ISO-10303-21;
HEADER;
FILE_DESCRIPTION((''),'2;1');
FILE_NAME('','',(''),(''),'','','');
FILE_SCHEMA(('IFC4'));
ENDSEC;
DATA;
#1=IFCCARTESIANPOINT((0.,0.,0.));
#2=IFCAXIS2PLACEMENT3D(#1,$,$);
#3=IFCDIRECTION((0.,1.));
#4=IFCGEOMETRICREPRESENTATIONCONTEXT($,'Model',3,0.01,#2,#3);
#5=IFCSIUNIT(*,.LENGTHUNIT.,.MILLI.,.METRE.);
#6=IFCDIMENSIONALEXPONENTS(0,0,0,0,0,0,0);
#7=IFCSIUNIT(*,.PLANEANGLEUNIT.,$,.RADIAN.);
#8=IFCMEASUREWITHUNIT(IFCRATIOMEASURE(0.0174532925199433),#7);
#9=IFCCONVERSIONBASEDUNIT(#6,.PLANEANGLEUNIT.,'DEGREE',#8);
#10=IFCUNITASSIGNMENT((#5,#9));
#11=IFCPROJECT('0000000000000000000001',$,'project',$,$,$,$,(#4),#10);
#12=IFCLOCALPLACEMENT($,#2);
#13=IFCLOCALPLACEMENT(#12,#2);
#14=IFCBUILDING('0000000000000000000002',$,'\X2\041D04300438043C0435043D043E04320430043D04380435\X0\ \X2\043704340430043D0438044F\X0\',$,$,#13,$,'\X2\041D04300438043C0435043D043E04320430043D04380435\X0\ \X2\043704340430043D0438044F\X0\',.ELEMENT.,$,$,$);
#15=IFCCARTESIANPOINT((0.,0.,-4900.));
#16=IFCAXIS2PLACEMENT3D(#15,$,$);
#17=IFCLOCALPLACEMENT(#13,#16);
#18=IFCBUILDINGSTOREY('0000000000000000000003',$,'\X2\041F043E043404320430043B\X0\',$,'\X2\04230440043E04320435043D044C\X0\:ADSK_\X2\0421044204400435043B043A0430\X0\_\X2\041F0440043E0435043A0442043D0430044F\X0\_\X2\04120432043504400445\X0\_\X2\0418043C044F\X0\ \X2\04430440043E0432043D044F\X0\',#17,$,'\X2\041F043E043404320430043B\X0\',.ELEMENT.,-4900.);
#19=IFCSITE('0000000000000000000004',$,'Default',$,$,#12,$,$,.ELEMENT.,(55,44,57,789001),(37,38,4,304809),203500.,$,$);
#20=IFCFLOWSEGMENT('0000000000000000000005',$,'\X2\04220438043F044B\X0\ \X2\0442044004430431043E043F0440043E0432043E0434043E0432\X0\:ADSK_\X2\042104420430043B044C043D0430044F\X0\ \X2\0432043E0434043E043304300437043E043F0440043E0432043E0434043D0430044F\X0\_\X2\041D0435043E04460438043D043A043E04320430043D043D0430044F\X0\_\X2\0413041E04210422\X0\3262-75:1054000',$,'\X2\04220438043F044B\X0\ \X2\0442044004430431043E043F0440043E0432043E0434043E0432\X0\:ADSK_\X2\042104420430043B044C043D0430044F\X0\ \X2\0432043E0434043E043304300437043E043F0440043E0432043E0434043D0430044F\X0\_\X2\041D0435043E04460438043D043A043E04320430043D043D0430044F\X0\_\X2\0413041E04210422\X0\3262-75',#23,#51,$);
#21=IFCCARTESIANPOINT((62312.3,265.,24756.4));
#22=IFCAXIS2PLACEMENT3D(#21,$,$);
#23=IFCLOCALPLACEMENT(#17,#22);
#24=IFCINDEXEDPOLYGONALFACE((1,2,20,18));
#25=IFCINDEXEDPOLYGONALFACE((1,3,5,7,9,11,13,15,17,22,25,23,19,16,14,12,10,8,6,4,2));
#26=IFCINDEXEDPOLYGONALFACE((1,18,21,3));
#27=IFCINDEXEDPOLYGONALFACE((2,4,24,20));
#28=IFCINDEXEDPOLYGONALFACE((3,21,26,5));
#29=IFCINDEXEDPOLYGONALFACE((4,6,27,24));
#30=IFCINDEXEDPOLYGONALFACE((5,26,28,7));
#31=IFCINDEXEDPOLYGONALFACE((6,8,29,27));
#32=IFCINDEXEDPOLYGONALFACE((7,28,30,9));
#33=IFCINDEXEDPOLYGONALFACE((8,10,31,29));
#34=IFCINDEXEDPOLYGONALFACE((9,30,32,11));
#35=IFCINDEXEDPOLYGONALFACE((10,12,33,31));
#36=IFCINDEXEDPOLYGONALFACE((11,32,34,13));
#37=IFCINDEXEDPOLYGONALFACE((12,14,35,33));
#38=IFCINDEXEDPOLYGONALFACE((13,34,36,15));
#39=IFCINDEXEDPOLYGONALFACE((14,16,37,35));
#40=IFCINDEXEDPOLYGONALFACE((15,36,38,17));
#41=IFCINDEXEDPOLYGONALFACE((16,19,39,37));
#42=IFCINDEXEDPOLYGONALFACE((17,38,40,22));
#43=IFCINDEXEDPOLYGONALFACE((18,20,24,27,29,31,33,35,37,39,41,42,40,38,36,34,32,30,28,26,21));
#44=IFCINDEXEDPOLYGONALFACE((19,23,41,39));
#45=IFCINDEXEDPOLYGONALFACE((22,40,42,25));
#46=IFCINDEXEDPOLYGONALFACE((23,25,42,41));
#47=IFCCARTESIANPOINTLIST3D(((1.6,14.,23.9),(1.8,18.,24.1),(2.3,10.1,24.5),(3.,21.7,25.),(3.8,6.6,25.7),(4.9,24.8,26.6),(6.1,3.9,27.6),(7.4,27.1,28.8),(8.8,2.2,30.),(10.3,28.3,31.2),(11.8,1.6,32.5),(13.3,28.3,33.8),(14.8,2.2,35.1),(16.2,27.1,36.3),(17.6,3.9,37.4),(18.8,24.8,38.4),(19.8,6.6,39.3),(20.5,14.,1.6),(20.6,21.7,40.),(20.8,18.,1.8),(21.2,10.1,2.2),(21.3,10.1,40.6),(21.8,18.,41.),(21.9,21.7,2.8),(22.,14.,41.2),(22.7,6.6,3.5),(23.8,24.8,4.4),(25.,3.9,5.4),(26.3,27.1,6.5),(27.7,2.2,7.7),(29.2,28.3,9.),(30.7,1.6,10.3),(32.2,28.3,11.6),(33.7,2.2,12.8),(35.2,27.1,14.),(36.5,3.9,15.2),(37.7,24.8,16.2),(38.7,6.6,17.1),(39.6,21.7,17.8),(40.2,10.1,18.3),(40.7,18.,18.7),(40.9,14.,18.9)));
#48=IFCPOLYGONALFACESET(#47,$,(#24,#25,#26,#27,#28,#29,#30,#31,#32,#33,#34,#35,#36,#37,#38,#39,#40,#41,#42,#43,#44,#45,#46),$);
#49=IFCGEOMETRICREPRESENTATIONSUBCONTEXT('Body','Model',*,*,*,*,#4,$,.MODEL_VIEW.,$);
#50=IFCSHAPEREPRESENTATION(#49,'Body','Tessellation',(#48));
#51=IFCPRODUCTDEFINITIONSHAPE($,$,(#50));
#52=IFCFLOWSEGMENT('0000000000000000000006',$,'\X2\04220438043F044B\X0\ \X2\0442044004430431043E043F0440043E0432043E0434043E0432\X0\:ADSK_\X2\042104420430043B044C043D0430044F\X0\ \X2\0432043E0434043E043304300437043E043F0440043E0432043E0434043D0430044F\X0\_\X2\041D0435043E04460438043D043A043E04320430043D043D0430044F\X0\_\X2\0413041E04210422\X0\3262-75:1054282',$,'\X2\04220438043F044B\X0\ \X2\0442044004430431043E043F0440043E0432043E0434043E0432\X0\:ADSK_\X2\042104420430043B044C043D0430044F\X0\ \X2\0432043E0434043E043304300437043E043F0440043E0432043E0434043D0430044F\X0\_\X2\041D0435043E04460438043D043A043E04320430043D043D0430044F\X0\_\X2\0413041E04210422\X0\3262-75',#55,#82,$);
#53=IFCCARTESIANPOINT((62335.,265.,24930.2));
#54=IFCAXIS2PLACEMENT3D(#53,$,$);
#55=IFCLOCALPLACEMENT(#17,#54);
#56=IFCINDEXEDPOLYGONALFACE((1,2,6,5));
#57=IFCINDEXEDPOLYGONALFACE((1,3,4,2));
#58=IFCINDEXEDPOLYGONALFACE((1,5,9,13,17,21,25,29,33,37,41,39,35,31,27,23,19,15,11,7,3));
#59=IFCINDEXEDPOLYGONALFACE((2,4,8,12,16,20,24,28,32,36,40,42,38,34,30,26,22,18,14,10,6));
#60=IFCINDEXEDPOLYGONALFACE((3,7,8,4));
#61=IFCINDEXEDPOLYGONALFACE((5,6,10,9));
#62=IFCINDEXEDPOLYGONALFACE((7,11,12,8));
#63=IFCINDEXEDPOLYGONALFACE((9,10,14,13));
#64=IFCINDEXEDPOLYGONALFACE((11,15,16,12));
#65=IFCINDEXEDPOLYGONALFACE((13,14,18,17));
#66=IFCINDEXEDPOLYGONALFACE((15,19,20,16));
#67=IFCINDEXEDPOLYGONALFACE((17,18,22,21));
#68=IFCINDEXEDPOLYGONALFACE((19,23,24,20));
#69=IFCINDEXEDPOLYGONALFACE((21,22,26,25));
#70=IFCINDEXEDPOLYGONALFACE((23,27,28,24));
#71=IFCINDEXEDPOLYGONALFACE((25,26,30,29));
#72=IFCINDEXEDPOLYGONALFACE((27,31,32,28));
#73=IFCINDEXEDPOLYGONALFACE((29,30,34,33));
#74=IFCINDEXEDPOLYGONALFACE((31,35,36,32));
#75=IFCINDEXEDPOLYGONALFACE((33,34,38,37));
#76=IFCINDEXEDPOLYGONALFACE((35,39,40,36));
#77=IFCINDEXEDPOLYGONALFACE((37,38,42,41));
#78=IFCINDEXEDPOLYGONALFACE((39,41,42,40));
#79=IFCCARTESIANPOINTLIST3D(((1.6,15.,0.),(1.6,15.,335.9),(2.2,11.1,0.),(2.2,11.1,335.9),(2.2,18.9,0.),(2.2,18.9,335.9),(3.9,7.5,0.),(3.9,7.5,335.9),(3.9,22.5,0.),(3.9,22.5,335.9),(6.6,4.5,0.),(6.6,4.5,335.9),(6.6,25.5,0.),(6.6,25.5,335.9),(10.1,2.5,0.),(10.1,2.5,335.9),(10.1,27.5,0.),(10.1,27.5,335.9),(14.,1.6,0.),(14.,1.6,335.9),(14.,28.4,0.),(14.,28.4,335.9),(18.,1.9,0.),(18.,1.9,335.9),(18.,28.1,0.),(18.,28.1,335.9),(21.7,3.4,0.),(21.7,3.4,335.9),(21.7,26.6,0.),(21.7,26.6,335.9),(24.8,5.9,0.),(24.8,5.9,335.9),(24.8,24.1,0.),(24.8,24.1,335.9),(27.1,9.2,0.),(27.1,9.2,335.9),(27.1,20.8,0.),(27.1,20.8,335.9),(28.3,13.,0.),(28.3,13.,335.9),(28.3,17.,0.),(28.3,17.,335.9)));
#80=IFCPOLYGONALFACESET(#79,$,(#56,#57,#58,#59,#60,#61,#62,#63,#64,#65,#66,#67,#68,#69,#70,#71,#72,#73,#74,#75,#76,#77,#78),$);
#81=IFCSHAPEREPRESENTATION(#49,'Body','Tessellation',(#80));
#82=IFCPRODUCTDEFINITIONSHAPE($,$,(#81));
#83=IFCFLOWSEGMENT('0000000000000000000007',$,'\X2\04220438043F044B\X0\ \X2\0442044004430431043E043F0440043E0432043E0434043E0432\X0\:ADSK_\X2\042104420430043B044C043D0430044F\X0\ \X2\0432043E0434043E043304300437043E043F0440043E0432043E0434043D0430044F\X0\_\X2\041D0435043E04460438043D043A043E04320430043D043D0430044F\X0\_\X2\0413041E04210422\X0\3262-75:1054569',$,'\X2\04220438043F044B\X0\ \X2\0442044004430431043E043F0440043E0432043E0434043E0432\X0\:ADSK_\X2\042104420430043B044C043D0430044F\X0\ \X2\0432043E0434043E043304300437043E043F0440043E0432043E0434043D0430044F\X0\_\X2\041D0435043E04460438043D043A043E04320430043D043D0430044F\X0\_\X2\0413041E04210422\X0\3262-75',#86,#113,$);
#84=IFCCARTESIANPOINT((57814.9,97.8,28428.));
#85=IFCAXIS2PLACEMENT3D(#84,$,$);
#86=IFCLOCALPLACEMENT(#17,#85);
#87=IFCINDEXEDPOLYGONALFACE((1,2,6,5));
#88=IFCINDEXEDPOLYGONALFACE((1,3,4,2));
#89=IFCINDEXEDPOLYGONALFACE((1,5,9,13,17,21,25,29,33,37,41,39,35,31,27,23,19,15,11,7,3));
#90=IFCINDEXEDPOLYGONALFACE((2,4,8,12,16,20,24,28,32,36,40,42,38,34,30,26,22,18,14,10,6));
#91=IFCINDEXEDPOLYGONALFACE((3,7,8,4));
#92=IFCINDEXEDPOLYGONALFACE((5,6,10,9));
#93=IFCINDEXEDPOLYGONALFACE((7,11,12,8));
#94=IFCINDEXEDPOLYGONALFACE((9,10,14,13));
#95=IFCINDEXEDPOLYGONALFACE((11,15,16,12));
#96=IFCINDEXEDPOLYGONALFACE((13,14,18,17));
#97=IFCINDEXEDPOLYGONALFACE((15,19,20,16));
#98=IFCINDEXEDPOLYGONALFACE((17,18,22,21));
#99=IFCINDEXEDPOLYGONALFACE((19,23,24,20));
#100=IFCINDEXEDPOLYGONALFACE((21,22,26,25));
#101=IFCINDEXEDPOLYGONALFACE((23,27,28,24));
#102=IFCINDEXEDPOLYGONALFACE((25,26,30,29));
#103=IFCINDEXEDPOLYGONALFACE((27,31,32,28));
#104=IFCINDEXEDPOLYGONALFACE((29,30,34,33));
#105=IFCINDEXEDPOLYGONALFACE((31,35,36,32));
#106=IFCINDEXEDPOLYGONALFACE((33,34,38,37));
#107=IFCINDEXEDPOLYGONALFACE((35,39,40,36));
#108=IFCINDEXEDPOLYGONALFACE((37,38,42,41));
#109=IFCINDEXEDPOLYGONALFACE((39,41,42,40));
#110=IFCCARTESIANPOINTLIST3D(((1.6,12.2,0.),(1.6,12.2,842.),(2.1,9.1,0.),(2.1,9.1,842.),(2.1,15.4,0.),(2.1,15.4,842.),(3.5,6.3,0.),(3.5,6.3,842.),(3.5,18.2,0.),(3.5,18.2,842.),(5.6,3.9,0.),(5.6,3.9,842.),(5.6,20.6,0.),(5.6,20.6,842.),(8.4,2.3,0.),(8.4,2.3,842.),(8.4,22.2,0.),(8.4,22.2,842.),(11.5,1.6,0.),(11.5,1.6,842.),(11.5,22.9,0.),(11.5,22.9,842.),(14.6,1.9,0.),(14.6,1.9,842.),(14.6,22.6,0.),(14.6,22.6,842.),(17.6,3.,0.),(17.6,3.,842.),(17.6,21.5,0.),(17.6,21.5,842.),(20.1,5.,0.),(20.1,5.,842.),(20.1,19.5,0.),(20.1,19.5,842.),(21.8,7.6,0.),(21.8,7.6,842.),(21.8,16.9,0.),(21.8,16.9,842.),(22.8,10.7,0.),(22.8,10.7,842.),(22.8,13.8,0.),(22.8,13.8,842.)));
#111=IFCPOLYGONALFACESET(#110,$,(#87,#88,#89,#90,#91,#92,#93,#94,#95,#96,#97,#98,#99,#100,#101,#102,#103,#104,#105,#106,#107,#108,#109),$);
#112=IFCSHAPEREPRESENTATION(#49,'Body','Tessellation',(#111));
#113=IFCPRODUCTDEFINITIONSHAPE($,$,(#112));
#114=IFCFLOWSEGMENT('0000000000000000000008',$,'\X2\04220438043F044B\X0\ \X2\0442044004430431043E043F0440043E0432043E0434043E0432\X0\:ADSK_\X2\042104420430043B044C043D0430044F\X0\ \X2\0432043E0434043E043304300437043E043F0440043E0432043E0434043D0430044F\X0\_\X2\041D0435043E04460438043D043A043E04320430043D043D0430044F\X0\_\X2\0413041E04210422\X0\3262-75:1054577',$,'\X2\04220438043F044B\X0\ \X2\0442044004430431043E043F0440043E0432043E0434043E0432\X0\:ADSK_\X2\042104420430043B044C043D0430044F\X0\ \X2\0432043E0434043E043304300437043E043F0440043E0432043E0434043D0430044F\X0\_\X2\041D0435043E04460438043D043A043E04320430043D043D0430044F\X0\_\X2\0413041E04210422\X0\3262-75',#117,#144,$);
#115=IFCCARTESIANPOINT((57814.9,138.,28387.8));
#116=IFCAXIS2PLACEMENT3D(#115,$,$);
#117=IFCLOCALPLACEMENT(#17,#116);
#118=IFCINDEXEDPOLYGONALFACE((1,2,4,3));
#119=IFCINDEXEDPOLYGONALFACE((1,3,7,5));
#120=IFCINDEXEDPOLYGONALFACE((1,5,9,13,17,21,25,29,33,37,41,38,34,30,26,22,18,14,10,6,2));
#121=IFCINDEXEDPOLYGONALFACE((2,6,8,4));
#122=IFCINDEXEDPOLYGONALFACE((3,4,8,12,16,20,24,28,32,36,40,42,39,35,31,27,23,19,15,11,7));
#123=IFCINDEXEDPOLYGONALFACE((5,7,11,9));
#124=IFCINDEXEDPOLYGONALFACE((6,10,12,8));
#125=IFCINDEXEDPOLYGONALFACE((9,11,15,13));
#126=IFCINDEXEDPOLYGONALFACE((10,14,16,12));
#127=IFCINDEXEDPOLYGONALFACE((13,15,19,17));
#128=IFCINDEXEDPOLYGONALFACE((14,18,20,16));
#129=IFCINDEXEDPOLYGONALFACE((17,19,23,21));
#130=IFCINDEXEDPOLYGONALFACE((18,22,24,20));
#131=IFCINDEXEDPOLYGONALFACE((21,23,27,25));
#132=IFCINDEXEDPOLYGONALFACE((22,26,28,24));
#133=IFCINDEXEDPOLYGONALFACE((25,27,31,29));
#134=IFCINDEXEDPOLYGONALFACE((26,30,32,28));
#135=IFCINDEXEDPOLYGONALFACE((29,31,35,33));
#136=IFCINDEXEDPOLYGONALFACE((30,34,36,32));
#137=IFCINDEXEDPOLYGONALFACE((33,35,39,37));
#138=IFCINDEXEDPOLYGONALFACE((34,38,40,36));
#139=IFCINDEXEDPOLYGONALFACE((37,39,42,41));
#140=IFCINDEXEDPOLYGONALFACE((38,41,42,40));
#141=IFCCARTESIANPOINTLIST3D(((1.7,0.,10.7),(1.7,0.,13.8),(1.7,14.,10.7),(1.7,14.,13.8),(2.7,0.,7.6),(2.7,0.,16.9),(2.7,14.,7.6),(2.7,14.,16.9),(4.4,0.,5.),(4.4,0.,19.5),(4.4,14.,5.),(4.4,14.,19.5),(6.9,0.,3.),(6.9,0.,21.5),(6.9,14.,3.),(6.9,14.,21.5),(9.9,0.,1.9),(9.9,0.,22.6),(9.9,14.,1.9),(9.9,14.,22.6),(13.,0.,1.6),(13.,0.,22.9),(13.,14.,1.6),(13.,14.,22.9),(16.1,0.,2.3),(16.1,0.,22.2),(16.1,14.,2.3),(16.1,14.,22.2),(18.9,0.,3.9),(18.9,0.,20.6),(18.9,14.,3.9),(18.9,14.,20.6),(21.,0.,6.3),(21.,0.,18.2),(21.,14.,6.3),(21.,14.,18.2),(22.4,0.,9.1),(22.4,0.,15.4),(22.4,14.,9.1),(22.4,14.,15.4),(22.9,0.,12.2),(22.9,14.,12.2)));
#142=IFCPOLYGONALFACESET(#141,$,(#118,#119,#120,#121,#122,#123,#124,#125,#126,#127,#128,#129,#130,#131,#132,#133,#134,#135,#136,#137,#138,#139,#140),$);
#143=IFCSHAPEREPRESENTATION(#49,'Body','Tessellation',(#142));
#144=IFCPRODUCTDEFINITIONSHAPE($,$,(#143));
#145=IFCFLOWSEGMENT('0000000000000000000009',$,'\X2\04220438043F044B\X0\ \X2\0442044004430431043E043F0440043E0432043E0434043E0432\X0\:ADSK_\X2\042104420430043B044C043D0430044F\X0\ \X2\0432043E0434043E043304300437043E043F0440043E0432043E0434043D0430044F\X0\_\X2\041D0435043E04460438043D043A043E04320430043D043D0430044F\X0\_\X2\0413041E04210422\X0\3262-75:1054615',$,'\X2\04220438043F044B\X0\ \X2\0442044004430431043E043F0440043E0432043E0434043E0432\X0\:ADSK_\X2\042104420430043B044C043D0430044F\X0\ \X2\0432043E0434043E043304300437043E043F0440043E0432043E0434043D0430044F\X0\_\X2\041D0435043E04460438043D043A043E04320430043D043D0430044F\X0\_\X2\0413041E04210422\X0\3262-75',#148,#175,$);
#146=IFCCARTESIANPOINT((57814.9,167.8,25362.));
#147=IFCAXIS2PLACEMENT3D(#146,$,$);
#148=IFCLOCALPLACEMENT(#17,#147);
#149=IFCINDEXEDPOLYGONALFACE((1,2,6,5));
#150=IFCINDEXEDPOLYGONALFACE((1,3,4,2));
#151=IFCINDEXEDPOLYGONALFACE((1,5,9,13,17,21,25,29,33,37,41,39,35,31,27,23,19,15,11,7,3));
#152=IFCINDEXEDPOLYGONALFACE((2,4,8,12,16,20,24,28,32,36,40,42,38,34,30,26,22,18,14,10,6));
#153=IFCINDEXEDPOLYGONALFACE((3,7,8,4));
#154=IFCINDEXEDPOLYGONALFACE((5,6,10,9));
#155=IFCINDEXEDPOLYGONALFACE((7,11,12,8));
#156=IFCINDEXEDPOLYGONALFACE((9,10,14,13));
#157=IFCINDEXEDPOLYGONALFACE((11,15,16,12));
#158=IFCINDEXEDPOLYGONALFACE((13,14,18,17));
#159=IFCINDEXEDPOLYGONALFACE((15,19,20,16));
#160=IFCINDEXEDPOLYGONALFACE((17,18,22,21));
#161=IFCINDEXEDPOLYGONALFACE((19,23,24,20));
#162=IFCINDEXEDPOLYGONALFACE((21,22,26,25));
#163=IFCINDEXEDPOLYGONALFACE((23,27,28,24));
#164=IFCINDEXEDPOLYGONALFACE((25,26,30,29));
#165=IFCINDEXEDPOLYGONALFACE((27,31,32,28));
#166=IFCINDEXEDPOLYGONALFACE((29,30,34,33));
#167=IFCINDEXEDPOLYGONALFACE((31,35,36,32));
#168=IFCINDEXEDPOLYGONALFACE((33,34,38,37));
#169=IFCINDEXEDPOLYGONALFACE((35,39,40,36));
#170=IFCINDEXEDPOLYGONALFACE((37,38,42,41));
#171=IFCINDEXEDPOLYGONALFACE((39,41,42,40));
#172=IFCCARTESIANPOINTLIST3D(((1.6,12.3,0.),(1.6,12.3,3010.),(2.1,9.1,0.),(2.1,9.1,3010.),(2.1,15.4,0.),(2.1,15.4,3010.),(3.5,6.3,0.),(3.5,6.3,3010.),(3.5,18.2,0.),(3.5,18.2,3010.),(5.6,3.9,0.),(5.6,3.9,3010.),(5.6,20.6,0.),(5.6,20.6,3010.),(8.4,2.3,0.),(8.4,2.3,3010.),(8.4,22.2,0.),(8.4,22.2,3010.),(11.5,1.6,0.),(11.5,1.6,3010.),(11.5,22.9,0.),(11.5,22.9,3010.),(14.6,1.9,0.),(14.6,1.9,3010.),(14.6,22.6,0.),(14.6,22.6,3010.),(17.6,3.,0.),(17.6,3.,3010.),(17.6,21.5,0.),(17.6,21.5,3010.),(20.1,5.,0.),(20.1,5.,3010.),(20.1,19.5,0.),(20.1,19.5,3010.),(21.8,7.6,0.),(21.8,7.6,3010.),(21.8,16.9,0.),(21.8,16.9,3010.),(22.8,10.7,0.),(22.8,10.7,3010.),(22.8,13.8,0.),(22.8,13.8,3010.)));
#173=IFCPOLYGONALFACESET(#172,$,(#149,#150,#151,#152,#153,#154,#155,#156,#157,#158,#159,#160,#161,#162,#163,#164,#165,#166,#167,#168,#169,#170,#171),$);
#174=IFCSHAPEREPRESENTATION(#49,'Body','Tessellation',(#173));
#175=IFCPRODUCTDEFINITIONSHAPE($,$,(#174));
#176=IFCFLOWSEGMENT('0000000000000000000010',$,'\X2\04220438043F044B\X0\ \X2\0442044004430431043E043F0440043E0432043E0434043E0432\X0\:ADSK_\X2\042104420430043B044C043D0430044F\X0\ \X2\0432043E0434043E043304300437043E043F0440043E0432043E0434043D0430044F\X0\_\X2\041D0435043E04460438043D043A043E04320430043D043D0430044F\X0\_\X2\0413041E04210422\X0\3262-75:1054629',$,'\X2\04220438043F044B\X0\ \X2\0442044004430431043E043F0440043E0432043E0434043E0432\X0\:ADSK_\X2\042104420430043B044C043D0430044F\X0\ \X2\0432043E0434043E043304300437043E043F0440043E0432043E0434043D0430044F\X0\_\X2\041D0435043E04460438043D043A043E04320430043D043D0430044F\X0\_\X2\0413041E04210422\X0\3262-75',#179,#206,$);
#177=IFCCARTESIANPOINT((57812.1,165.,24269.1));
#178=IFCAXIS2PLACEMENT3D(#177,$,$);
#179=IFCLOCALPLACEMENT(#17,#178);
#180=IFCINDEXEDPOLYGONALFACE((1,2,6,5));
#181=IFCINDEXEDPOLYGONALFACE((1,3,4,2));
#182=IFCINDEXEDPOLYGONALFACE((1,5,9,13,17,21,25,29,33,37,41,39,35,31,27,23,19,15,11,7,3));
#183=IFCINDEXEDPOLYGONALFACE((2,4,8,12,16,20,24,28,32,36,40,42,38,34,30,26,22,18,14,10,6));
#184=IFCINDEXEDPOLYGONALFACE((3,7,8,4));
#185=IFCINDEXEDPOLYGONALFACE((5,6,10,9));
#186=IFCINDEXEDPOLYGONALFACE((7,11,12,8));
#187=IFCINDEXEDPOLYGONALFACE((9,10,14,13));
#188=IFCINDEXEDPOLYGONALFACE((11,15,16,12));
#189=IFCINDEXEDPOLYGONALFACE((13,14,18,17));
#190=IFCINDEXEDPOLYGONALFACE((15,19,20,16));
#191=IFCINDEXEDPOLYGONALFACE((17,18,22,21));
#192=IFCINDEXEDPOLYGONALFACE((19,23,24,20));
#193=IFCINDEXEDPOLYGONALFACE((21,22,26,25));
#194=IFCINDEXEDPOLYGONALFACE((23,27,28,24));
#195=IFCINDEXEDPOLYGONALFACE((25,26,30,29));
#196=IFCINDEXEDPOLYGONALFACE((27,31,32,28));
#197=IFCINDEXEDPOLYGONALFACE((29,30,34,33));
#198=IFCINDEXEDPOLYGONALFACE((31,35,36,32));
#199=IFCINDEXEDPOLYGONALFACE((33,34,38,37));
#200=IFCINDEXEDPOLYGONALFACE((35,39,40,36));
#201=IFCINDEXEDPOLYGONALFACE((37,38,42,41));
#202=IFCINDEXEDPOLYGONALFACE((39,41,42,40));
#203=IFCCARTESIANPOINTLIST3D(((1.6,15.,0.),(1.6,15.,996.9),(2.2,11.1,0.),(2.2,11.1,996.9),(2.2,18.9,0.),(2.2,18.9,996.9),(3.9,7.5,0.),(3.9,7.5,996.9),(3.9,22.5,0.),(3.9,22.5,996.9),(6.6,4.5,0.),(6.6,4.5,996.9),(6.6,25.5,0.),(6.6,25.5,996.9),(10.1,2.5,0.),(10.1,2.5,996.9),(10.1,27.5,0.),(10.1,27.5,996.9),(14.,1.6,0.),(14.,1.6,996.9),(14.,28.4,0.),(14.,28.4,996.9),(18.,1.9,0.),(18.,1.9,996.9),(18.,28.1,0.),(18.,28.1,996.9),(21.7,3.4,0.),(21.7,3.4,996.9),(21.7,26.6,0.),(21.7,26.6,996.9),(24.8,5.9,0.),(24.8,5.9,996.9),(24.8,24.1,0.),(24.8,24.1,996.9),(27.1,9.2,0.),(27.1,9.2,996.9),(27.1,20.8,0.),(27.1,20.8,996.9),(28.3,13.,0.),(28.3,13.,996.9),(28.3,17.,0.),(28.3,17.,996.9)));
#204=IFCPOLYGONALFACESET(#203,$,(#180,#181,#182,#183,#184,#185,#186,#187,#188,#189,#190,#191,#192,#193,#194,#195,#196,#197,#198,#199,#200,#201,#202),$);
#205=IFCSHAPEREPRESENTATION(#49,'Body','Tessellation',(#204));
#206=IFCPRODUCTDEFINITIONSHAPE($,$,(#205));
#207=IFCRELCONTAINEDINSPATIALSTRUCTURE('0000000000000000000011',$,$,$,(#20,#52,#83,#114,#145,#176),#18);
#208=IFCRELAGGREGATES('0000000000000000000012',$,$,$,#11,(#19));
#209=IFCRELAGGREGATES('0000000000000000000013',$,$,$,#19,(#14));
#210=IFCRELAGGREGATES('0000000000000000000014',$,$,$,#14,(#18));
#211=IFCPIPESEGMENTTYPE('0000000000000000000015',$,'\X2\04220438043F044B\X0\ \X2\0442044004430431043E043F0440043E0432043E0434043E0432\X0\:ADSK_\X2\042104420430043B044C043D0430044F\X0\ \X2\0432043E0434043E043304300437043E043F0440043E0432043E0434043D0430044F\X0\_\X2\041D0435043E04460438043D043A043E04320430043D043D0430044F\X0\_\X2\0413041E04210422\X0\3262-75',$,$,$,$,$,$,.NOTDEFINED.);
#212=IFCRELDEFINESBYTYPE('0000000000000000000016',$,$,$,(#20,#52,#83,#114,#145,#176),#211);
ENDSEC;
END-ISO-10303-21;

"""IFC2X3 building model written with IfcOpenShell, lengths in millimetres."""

from ifc_helpers import new_model, entity, si_unit, converted_unit, direction, frame, origin, origin_2d_with_axis, place, context, subcontext, project, spatial, circle, extrude, type_object, element, save


model = new_model("IFC2X3")

# Units and contexts
model_context = context("Model", 3, precision=0.01, world=origin(), true_north=direction((0.0, 1.0)))
body_context = subcontext(model_context, "Body", "Model", "MODEL_VIEW")
ifc_project = project(units=[si_unit("LENGTHUNIT", "METRE", prefix="MILLI"), converted_unit("PLANEANGLEUNIT", "DEGREE", entity("IfcRatioMeasure", 0.0174532925199433), si_unit("PLANEANGLEUNIT", "RADIAN"), dimensions=[0, 0, 0, 0, 0, 0, 0])], contexts=[model_context])

# Site, building, storey
site_placement = place(None, origin())
site = spatial("IfcSite", under=ifc_project, at=site_placement, Name="Default", CompositionType="ELEMENT", RefLatitude=(55, 44, 57, 789001), RefLongitude=(37, 38, 4, 304809), RefElevation=203500.0)
building_placement = place(site_placement, origin())
building = spatial("IfcBuilding", under=site, at=building_placement, Name="Наименование здания", LongName="Наименование здания", CompositionType="ELEMENT")
storey_placement = place(building_placement, frame((0.0, 0.0, -4900.0)))
storey = spatial("IfcBuildingStorey", under=building, at=storey_placement, Name="Подвал", ObjectType="Уровень:ADSK_Стрелка_Проектная_Вверх_Имя уровня", LongName="Подвал", CompositionType="ELEMENT", Elevation=-4900.0)

# Flow segments
pipe_segment_type = type_object("IfcPipeSegmentType", Name="Типы трубопроводов:ADSK_Стальная водогазопроводная_Неоцинкованная_ГОСТ3262-75", PredefinedType="NOTDEFINED")
flow_segment_1_placement = place(storey_placement, frame((62312.3, 265.0, 24756.4)))
element("IfcFlowSegment", 1, at=flow_segment_1_placement, inside=storey, type_object=pipe_segment_type, Name="Типы трубопроводов:ADSK_Стальная водогазопроводная_Неоцинкованная_ГОСТ3262-75:1054000", ObjectType="Типы трубопроводов:ADSK_Стальная водогазопроводная_Неоцинкованная_ГОСТ3262-75", context=body_context, shape_type="SweptSolid", body=[
    extrude(circle(Radius=13.4, at=origin_2d_with_axis()), frame((30.7, 15.0, 10.3), z_axis=(-0.647564, 0.0, 0.762011), x_axis=(0.0, -1.0, 0.0)), (0.0, 0.0, 1.0), 29.2),
])
flow_segment_2_placement = place(storey_placement, frame((62335.0, 265.0, 24930.2)))
element("IfcFlowSegment", 2, at=flow_segment_2_placement, inside=storey, type_object=pipe_segment_type, Name="Типы трубопроводов:ADSK_Стальная водогазопроводная_Неоцинкованная_ГОСТ3262-75:1054282", ObjectType="Типы трубопроводов:ADSK_Стальная водогазопроводная_Неоцинкованная_ГОСТ3262-75", context=body_context, shape_type="SweptSolid", body=[
    extrude(circle(Radius=13.4, at=origin_2d_with_axis()), frame((15.0, 15.0, 0.0), z_axis=(0.0, 0.0, 1.0), x_axis=(-1.0, 0.0, 0.0)), (0.0, 0.0, 1.0), 335.9),
])
flow_segment_3_placement = place(storey_placement, frame((57814.9, 97.8, 28428.0)))
element("IfcFlowSegment", 3, at=flow_segment_3_placement, inside=storey, type_object=pipe_segment_type, Name="Типы трубопроводов:ADSK_Стальная водогазопроводная_Неоцинкованная_ГОСТ3262-75:1054569", ObjectType="Типы трубопроводов:ADSK_Стальная водогазопроводная_Неоцинкованная_ГОСТ3262-75", context=body_context, shape_type="SweptSolid", body=[
    extrude(circle(Radius=10.7, at=origin_2d_with_axis()), frame((12.2, 12.2, 0.0), z_axis=(0.0, 0.0, 1.0), x_axis=(-1.0, 0.0, 0.0)), (0.0, 0.0, 1.0), 842.0),
])
flow_segment_4_placement = place(storey_placement, frame((57814.9, 138.0, 28387.8)))
element("IfcFlowSegment", 4, at=flow_segment_4_placement, inside=storey, type_object=pipe_segment_type, Name="Типы трубопроводов:ADSK_Стальная водогазопроводная_Неоцинкованная_ГОСТ3262-75:1054577", ObjectType="Типы трубопроводов:ADSK_Стальная водогазопроводная_Неоцинкованная_ГОСТ3262-75", context=body_context, shape_type="SweptSolid", body=[
    extrude(circle(Radius=10.7, at=origin_2d_with_axis()), frame((12.2, 0.0, 12.2), z_axis=(0.0, 1.0, 0.0), x_axis=(1.0, 0.0, 0.0)), (0.0, 0.0, 1.0), 14.0),
])
flow_segment_5_placement = place(storey_placement, frame((57814.9, 167.8, 25362.0)))
element("IfcFlowSegment", 5, at=flow_segment_5_placement, inside=storey, type_object=pipe_segment_type, Name="Типы трубопроводов:ADSK_Стальная водогазопроводная_Неоцинкованная_ГОСТ3262-75:1054615", ObjectType="Типы трубопроводов:ADSK_Стальная водогазопроводная_Неоцинкованная_ГОСТ3262-75", context=body_context, shape_type="SweptSolid", body=[
    extrude(circle(Radius=10.7, at=origin_2d_with_axis()), frame((12.2, 12.2, 0.0), z_axis=(0.0, 0.0, 1.0), x_axis=(-1.0, 0.0, 0.0)), (0.0, 0.0, 1.0), 3010.0),
])
flow_segment_6_placement = place(storey_placement, frame((57812.1, 165.0, 24269.1)))
element("IfcFlowSegment", 6, at=flow_segment_6_placement, inside=storey, type_object=pipe_segment_type, Name="Типы трубопроводов:ADSK_Стальная водогазопроводная_Неоцинкованная_ГОСТ3262-75:1054629", ObjectType="Типы трубопроводов:ADSK_Стальная водогазопроводная_Неоцинкованная_ГОСТ3262-75", context=body_context, shape_type="SweptSolid", body=[
    extrude(circle(Radius=13.4, at=origin_2d_with_axis()), frame((15.0, 15.0, 0.0), z_axis=(0.0, 0.0, 1.0), x_axis=(-1.0, 0.0, 0.0)), (0.0, 0.0, 1.0), 996.9),
])

save(model, "model.ifc")
